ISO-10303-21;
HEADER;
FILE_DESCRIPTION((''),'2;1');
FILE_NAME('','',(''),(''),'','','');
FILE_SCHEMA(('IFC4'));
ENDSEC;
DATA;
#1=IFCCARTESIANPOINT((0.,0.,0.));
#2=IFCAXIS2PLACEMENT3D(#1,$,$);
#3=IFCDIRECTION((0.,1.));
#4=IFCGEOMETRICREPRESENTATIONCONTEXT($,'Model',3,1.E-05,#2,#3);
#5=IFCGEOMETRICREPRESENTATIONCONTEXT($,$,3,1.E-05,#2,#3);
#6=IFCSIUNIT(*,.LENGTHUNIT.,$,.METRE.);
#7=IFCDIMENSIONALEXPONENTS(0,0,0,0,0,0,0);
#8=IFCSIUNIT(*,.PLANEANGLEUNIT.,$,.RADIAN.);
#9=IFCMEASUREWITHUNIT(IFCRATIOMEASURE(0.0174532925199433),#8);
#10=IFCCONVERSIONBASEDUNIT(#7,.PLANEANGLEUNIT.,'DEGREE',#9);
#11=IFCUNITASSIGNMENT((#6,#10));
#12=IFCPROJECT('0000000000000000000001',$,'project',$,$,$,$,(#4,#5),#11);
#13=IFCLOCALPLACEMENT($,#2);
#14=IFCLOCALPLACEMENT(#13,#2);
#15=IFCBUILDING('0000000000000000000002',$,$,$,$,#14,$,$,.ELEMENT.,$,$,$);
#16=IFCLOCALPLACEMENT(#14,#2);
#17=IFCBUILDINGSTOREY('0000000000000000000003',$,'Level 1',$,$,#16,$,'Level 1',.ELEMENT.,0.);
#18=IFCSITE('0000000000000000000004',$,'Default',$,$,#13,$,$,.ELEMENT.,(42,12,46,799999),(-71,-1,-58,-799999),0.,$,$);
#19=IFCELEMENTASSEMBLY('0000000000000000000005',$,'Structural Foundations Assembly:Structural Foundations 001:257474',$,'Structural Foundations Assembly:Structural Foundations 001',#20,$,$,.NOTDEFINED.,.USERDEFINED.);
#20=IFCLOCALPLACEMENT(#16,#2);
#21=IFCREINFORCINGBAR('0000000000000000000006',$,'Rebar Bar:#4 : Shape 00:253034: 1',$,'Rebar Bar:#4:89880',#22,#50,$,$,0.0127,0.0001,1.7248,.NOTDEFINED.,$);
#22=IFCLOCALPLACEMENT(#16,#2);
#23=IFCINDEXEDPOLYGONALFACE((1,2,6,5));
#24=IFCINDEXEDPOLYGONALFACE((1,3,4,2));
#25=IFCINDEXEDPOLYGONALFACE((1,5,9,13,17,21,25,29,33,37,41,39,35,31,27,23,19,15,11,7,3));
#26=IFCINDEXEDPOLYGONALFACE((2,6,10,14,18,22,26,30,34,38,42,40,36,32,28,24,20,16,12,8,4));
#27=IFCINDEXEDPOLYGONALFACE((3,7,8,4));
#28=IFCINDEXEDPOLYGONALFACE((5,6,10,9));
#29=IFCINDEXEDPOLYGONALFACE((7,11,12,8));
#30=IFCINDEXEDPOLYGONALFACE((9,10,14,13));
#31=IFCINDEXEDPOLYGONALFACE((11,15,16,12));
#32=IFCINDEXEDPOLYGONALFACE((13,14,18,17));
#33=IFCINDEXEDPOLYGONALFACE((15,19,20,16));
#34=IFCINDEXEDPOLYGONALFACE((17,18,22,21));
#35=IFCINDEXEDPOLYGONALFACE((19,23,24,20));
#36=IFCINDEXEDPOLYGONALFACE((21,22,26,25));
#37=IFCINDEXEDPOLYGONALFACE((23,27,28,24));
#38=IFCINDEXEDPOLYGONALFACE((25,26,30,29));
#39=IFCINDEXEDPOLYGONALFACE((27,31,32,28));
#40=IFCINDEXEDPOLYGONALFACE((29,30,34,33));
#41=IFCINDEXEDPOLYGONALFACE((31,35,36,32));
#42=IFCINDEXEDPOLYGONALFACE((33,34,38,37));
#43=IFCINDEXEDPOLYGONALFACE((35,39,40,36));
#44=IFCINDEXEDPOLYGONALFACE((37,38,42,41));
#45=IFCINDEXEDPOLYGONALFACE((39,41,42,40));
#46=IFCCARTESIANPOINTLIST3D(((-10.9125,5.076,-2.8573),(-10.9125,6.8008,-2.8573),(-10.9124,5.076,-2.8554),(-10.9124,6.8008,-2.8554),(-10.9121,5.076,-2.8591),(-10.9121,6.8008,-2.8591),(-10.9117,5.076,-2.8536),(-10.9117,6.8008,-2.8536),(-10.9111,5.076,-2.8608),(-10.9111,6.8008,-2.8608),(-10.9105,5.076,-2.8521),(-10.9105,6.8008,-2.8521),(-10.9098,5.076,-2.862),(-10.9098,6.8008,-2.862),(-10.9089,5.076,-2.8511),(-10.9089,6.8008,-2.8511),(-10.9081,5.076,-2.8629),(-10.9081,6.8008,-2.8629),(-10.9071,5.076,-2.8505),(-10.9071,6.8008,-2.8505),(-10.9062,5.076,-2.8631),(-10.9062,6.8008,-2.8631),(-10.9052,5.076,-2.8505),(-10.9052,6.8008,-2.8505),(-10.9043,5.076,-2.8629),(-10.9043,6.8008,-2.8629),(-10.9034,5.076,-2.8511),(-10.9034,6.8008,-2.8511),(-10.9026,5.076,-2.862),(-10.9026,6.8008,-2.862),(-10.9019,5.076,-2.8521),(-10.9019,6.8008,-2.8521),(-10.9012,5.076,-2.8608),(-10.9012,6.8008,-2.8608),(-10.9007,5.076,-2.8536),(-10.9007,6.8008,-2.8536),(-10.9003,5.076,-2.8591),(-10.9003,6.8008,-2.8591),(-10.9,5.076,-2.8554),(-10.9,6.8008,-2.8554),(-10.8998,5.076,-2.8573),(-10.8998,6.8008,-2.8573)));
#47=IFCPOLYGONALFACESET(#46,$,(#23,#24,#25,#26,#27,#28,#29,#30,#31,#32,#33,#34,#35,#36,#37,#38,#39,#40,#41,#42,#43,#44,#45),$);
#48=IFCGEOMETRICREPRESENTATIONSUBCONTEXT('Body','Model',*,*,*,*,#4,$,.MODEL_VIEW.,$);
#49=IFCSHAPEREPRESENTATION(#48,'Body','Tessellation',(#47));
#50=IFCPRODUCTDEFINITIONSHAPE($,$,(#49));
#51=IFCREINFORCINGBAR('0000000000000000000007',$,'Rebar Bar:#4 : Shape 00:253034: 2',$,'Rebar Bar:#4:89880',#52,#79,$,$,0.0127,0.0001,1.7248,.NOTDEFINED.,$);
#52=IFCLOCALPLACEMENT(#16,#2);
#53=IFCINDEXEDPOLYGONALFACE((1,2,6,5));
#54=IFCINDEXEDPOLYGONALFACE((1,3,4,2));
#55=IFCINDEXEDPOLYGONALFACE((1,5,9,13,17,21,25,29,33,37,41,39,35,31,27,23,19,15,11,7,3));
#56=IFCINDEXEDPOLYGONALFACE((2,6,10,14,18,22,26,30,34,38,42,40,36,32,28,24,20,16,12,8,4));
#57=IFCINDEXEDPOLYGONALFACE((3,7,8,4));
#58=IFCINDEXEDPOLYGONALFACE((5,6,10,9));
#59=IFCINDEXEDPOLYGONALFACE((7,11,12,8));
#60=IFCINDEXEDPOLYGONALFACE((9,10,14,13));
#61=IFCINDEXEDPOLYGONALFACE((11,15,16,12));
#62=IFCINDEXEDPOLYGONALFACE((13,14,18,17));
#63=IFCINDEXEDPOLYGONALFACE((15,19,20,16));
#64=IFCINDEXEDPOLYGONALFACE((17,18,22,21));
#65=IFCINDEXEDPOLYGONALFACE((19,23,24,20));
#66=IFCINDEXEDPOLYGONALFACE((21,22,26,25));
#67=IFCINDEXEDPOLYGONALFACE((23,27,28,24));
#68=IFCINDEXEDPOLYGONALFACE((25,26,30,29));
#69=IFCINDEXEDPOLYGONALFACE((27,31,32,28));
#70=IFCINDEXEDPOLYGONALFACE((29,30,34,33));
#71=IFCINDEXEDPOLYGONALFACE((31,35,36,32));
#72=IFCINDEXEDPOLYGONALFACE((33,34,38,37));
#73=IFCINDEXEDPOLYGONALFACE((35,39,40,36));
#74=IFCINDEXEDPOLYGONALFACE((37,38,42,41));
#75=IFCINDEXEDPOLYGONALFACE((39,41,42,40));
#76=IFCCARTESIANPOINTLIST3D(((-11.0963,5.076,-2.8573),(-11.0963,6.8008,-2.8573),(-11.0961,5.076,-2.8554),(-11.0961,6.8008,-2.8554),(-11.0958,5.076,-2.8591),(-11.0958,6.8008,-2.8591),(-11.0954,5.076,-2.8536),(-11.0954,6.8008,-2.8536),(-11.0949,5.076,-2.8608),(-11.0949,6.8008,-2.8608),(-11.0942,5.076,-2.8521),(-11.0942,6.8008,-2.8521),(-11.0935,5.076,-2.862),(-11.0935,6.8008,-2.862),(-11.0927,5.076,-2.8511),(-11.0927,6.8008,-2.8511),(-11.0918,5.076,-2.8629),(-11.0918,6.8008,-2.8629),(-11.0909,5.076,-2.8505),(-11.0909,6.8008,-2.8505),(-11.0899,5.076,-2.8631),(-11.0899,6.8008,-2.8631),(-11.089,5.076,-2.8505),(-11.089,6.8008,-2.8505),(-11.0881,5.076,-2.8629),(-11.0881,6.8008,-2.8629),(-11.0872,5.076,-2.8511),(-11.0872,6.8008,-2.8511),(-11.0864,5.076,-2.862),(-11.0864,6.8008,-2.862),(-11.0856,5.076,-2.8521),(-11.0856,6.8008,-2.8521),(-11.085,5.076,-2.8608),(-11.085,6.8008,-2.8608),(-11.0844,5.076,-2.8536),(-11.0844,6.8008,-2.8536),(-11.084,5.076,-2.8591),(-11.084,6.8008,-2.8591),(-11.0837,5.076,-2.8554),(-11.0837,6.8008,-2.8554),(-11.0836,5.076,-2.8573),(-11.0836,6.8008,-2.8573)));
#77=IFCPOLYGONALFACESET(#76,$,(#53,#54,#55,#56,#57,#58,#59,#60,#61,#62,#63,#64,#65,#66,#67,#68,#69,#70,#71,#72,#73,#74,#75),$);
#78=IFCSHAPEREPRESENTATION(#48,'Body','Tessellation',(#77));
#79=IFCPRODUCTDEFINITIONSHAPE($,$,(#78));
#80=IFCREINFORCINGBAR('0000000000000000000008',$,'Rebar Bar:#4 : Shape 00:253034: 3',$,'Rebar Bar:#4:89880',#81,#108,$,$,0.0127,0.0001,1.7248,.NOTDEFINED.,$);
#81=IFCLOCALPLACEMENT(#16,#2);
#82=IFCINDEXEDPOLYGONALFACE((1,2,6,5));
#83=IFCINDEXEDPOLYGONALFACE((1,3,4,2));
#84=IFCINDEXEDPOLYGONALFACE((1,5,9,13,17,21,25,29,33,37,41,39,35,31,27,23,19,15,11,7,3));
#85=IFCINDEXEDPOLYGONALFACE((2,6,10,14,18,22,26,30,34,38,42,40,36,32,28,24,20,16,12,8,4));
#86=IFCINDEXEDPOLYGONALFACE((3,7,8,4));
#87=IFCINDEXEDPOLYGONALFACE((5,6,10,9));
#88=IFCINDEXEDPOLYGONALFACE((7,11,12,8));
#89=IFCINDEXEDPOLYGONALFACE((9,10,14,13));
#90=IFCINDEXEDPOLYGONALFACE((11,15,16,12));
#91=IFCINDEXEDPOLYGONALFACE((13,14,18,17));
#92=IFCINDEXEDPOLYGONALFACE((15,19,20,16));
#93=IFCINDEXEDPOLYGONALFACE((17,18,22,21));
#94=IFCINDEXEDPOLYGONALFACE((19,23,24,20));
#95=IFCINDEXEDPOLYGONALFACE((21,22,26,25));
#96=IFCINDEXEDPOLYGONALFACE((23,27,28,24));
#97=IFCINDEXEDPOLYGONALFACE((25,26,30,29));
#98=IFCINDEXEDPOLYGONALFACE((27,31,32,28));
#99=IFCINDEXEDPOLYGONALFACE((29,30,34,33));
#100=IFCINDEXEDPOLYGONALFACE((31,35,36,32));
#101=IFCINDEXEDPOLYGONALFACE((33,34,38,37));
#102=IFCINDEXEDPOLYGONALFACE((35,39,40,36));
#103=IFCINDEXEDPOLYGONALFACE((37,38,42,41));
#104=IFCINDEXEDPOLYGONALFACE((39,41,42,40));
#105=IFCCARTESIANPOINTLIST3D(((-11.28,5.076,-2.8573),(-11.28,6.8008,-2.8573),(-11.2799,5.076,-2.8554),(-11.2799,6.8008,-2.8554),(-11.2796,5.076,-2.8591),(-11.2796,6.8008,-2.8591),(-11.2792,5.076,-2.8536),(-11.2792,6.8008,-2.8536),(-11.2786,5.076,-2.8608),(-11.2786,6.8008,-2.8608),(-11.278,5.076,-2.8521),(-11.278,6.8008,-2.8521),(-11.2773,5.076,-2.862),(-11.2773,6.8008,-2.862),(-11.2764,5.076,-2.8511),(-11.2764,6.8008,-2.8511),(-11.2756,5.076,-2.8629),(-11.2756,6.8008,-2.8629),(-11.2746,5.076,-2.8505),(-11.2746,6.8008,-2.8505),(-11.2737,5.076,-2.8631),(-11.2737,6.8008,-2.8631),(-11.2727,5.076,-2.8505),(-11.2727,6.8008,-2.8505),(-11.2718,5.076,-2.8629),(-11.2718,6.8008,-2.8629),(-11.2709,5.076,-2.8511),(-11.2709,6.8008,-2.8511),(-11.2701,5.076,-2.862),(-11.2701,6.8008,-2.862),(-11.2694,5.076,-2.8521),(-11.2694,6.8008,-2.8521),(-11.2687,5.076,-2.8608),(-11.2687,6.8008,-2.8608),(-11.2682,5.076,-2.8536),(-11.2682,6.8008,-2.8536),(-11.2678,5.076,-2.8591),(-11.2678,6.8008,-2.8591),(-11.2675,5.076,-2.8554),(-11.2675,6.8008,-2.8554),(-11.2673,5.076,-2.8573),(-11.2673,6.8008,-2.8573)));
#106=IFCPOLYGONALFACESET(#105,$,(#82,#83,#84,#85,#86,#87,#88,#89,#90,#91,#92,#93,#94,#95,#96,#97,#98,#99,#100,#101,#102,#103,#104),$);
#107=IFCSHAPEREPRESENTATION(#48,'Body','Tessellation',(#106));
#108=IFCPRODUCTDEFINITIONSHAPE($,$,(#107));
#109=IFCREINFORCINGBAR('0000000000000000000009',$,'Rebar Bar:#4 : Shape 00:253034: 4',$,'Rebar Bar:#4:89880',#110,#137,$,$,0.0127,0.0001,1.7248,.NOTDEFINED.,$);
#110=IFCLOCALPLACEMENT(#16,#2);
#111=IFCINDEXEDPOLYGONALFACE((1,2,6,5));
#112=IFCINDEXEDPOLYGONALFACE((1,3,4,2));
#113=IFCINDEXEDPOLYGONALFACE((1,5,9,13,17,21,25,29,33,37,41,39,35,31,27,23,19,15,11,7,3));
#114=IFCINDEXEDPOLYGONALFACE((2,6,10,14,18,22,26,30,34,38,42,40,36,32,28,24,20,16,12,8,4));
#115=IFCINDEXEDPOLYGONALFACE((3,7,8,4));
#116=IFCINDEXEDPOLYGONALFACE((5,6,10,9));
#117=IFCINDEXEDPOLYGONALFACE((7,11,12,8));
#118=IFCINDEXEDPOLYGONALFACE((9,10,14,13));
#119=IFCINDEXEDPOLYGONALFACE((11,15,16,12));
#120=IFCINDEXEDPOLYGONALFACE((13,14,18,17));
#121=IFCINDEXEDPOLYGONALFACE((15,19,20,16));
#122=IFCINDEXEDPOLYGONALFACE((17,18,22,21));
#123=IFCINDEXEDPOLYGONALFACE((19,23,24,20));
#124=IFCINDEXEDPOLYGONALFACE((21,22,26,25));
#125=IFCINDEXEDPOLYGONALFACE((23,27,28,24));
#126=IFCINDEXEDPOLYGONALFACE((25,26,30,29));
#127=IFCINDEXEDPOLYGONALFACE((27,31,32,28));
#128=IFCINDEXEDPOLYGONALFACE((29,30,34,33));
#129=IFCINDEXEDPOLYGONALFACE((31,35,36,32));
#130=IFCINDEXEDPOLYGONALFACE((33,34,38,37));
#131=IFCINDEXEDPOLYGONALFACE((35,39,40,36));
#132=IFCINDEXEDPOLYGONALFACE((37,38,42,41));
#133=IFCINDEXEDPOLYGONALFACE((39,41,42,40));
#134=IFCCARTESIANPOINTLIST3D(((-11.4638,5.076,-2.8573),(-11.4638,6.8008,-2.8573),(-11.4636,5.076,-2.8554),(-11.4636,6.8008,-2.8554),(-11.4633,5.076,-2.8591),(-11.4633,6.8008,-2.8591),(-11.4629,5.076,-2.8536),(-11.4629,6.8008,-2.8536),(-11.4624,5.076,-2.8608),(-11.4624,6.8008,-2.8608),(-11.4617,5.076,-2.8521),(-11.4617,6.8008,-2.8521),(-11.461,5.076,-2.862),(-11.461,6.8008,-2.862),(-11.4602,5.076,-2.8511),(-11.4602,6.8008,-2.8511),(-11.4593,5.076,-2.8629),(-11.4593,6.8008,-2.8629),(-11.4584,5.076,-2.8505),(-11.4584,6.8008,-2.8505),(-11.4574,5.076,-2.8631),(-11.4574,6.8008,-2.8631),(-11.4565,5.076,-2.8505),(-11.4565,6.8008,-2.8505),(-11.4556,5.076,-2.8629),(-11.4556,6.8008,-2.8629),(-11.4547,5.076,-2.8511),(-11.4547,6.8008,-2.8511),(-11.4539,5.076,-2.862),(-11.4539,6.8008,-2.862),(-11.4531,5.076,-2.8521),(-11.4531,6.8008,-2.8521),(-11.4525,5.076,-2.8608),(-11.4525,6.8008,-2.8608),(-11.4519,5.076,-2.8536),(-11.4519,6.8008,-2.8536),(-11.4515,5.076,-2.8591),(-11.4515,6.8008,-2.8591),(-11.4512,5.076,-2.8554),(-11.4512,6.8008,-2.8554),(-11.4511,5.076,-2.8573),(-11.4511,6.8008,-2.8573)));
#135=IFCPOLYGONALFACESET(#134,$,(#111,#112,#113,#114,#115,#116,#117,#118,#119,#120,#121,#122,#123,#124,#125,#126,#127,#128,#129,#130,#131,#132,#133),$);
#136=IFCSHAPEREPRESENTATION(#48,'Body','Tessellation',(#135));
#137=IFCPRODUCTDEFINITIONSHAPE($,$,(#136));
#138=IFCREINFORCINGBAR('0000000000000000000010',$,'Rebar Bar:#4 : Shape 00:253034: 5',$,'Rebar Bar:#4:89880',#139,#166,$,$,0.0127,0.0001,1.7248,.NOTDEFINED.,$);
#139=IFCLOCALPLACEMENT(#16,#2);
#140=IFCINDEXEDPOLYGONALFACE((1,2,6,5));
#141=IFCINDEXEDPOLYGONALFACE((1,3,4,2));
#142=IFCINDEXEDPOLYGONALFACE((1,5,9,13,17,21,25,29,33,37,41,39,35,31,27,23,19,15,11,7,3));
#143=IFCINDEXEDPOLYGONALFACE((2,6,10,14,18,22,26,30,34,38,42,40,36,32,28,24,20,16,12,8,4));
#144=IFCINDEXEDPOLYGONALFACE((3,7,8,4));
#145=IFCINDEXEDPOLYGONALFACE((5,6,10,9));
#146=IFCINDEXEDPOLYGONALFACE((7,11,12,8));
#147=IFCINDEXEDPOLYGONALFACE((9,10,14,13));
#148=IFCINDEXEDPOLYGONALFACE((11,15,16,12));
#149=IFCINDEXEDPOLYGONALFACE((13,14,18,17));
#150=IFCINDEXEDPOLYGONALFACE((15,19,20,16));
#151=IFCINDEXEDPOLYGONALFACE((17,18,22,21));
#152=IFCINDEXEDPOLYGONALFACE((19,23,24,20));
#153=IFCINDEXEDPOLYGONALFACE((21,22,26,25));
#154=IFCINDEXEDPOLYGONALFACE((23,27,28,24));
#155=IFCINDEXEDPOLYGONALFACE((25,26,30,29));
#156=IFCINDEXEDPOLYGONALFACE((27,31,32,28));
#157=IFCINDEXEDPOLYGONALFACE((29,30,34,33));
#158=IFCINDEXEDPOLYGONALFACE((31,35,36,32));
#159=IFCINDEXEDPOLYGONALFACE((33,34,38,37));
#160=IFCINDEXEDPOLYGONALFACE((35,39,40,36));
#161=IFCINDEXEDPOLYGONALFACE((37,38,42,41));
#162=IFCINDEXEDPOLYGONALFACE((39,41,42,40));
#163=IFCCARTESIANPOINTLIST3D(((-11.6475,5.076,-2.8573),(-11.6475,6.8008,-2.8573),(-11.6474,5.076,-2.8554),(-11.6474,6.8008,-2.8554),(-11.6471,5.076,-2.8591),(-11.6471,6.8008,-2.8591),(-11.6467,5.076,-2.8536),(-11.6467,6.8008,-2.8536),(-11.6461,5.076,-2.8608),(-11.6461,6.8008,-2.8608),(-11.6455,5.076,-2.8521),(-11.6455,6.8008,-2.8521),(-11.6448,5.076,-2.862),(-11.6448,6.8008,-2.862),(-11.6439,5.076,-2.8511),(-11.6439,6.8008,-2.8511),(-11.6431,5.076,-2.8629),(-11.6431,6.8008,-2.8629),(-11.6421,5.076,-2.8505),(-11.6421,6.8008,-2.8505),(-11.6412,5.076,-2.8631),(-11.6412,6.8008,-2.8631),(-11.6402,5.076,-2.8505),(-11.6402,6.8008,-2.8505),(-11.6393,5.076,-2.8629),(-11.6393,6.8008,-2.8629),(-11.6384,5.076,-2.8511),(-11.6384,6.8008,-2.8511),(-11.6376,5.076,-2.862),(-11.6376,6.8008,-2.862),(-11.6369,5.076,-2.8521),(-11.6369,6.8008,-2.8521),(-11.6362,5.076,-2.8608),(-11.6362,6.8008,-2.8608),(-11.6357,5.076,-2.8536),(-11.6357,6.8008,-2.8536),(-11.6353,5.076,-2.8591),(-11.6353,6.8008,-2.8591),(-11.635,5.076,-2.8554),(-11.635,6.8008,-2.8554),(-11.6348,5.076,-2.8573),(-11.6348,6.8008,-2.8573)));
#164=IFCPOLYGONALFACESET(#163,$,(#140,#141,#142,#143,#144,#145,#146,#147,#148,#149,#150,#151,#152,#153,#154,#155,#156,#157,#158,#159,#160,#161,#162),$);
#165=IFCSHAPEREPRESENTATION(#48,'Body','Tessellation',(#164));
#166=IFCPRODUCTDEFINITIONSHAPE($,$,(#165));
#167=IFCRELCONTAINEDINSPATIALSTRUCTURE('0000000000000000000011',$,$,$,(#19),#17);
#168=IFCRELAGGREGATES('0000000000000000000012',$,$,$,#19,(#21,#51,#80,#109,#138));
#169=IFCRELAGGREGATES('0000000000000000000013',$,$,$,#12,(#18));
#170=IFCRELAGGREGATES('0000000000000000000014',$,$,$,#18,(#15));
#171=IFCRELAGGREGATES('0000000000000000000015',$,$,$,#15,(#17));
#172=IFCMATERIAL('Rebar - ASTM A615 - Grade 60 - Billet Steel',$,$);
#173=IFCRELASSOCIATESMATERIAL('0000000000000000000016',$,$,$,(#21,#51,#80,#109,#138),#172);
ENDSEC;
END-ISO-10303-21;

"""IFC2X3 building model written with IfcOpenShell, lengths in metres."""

from ifc_helpers import new_model, entity, si_unit, converted_unit, direction, origin, place, context, subcontext, project, spatial, material, element, aggregate, save


model = new_model("IFC2X3")

# Units and contexts
model_context = context("Model", 3, precision=1e-05, world=origin(), true_north=direction((0.0, 1.0)))
context_of_model = context(None, 3, precision=1e-05, world=origin(), true_north=direction((0.0, 1.0)))
body_context = subcontext(model_context, "Body", "Model", "MODEL_VIEW")
ifc_project = project(units=[si_unit("LENGTHUNIT", "METRE"), converted_unit("PLANEANGLEUNIT", "DEGREE", entity("IfcRatioMeasure", 0.0174532925199433), si_unit("PLANEANGLEUNIT", "RADIAN"), dimensions=[0, 0, 0, 0, 0, 0, 0])], contexts=[model_context, context_of_model])

# Site, building, storey
site_placement = place(None, origin())
site = spatial("IfcSite", under=ifc_project, at=site_placement, Name="Default", CompositionType="ELEMENT", RefLatitude=(42, 12, 46, 799999), RefLongitude=(-71, -1, -58, -799999), RefElevation=0.0)
building_placement = place(site_placement, origin())
building = spatial("IfcBuilding", under=site, at=building_placement, CompositionType="ELEMENT")
storey_placement = place(building_placement, origin())
storey = spatial("IfcBuildingStorey", under=building, at=storey_placement, Name="Level 1", LongName="Level 1", CompositionType="ELEMENT", Elevation=0.0)

# Element assembly, reinforcing bars
assembly_placement = place(storey_placement, origin())
assembly = element("IfcElementAssembly", 1, at=assembly_placement, inside=storey, Name="Structural Foundations Assembly:Structural Foundations 001:257474", ObjectType="Structural Foundations Assembly:Structural Foundations 001", AssemblyPlace="NOTDEFINED", PredefinedType="USERDEFINED")
ifc_material = material(Name="Rebar - ASTM A615 - Grade 60 - Billet Steel")
reinforcing_bar_1_placement = place(assembly_placement, origin())
reinforcing_bar_1 = element("IfcReinforcingBar", 2, at=reinforcing_bar_1_placement, material=ifc_material, Name="Rebar Bar:#4 : Shape 00:253034: 1", ObjectType="Rebar Bar:#4:89880", BarLength=1.7248, BarRole="NOTDEFINED", CrossSectionArea=0.0001, NominalDiameter=0.0127, context=body_context, shape_type="AdvancedSweptSolid", body=[
    entity("IfcSweptDiskSolid", entity("IfcCompositeCurve", [entity("IfcCompositeCurveSegment", "CONTINUOUS", True, entity("IfcPolyline", [entity("IfcCartesianPoint", [-10.9062, 6.8008, -2.8568]), entity("IfcCartesianPoint", [-10.9062, 5.076, -2.8568])]))], False), 0.0063, None, 0.0, 1.0),
])
reinforcing_bar_2_placement = place(assembly_placement, origin())
reinforcing_bar_2 = element("IfcReinforcingBar", 3, at=reinforcing_bar_2_placement, material=ifc_material, Name="Rebar Bar:#4 : Shape 00:253034: 2", ObjectType="Rebar Bar:#4:89880", BarLength=1.7248, BarRole="NOTDEFINED", CrossSectionArea=0.0001, NominalDiameter=0.0127, context=body_context, shape_type="AdvancedSweptSolid", body=[
    entity("IfcSweptDiskSolid", entity("IfcCompositeCurve", [entity("IfcCompositeCurveSegment", "CONTINUOUS", True, entity("IfcPolyline", [entity("IfcCartesianPoint", [-11.0899, 6.8008, -2.8568]), entity("IfcCartesianPoint", [-11.0899, 5.076, -2.8568])]))], False), 0.0063, None, 0.0, 1.0),
])
reinforcing_bar_3_placement = place(assembly_placement, origin())
reinforcing_bar_3 = element("IfcReinforcingBar", 4, at=reinforcing_bar_3_placement, material=ifc_material, Name="Rebar Bar:#4 : Shape 00:253034: 3", ObjectType="Rebar Bar:#4:89880", BarLength=1.7248, BarRole="NOTDEFINED", CrossSectionArea=0.0001, NominalDiameter=0.0127, context=body_context, shape_type="AdvancedSweptSolid", body=[
    entity("IfcSweptDiskSolid", entity("IfcCompositeCurve", [entity("IfcCompositeCurveSegment", "CONTINUOUS", True, entity("IfcPolyline", [entity("IfcCartesianPoint", [-11.2737, 6.8008, -2.8568]), entity("IfcCartesianPoint", [-11.2737, 5.076, -2.8568])]))], False), 0.0063, None, 0.0, 1.0),
])
reinforcing_bar_4_placement = place(assembly_placement, origin())
reinforcing_bar_4 = element("IfcReinforcingBar", 5, at=reinforcing_bar_4_placement, material=ifc_material, Name="Rebar Bar:#4 : Shape 00:253034: 4", ObjectType="Rebar Bar:#4:89880", BarLength=1.7248, BarRole="NOTDEFINED", CrossSectionArea=0.0001, NominalDiameter=0.0127, context=body_context, shape_type="AdvancedSweptSolid", body=[
    entity("IfcSweptDiskSolid", entity("IfcCompositeCurve", [entity("IfcCompositeCurveSegment", "CONTINUOUS", True, entity("IfcPolyline", [entity("IfcCartesianPoint", [-11.4574, 6.8008, -2.8568]), entity("IfcCartesianPoint", [-11.4574, 5.076, -2.8568])]))], False), 0.0063, None, 0.0, 1.0),
])
reinforcing_bar_5_placement = place(assembly_placement, origin())
reinforcing_bar_5 = element("IfcReinforcingBar", 6, at=reinforcing_bar_5_placement, material=ifc_material, Name="Rebar Bar:#4 : Shape 00:253034: 5", ObjectType="Rebar Bar:#4:89880", BarLength=1.7248, BarRole="NOTDEFINED", CrossSectionArea=0.0001, NominalDiameter=0.0127, context=body_context, shape_type="AdvancedSweptSolid", body=[
    entity("IfcSweptDiskSolid", entity("IfcCompositeCurve", [entity("IfcCompositeCurveSegment", "CONTINUOUS", True, entity("IfcPolyline", [entity("IfcCartesianPoint", [-11.6412, 6.8008, -2.8568]), entity("IfcCartesianPoint", [-11.6412, 5.076, -2.8568])]))], False), 0.0063, None, 0.0, 1.0),
])
aggregate(assembly, [reinforcing_bar_1, reinforcing_bar_2, reinforcing_bar_3, reinforcing_bar_4, reinforcing_bar_5])

save(model, "model.ifc")
